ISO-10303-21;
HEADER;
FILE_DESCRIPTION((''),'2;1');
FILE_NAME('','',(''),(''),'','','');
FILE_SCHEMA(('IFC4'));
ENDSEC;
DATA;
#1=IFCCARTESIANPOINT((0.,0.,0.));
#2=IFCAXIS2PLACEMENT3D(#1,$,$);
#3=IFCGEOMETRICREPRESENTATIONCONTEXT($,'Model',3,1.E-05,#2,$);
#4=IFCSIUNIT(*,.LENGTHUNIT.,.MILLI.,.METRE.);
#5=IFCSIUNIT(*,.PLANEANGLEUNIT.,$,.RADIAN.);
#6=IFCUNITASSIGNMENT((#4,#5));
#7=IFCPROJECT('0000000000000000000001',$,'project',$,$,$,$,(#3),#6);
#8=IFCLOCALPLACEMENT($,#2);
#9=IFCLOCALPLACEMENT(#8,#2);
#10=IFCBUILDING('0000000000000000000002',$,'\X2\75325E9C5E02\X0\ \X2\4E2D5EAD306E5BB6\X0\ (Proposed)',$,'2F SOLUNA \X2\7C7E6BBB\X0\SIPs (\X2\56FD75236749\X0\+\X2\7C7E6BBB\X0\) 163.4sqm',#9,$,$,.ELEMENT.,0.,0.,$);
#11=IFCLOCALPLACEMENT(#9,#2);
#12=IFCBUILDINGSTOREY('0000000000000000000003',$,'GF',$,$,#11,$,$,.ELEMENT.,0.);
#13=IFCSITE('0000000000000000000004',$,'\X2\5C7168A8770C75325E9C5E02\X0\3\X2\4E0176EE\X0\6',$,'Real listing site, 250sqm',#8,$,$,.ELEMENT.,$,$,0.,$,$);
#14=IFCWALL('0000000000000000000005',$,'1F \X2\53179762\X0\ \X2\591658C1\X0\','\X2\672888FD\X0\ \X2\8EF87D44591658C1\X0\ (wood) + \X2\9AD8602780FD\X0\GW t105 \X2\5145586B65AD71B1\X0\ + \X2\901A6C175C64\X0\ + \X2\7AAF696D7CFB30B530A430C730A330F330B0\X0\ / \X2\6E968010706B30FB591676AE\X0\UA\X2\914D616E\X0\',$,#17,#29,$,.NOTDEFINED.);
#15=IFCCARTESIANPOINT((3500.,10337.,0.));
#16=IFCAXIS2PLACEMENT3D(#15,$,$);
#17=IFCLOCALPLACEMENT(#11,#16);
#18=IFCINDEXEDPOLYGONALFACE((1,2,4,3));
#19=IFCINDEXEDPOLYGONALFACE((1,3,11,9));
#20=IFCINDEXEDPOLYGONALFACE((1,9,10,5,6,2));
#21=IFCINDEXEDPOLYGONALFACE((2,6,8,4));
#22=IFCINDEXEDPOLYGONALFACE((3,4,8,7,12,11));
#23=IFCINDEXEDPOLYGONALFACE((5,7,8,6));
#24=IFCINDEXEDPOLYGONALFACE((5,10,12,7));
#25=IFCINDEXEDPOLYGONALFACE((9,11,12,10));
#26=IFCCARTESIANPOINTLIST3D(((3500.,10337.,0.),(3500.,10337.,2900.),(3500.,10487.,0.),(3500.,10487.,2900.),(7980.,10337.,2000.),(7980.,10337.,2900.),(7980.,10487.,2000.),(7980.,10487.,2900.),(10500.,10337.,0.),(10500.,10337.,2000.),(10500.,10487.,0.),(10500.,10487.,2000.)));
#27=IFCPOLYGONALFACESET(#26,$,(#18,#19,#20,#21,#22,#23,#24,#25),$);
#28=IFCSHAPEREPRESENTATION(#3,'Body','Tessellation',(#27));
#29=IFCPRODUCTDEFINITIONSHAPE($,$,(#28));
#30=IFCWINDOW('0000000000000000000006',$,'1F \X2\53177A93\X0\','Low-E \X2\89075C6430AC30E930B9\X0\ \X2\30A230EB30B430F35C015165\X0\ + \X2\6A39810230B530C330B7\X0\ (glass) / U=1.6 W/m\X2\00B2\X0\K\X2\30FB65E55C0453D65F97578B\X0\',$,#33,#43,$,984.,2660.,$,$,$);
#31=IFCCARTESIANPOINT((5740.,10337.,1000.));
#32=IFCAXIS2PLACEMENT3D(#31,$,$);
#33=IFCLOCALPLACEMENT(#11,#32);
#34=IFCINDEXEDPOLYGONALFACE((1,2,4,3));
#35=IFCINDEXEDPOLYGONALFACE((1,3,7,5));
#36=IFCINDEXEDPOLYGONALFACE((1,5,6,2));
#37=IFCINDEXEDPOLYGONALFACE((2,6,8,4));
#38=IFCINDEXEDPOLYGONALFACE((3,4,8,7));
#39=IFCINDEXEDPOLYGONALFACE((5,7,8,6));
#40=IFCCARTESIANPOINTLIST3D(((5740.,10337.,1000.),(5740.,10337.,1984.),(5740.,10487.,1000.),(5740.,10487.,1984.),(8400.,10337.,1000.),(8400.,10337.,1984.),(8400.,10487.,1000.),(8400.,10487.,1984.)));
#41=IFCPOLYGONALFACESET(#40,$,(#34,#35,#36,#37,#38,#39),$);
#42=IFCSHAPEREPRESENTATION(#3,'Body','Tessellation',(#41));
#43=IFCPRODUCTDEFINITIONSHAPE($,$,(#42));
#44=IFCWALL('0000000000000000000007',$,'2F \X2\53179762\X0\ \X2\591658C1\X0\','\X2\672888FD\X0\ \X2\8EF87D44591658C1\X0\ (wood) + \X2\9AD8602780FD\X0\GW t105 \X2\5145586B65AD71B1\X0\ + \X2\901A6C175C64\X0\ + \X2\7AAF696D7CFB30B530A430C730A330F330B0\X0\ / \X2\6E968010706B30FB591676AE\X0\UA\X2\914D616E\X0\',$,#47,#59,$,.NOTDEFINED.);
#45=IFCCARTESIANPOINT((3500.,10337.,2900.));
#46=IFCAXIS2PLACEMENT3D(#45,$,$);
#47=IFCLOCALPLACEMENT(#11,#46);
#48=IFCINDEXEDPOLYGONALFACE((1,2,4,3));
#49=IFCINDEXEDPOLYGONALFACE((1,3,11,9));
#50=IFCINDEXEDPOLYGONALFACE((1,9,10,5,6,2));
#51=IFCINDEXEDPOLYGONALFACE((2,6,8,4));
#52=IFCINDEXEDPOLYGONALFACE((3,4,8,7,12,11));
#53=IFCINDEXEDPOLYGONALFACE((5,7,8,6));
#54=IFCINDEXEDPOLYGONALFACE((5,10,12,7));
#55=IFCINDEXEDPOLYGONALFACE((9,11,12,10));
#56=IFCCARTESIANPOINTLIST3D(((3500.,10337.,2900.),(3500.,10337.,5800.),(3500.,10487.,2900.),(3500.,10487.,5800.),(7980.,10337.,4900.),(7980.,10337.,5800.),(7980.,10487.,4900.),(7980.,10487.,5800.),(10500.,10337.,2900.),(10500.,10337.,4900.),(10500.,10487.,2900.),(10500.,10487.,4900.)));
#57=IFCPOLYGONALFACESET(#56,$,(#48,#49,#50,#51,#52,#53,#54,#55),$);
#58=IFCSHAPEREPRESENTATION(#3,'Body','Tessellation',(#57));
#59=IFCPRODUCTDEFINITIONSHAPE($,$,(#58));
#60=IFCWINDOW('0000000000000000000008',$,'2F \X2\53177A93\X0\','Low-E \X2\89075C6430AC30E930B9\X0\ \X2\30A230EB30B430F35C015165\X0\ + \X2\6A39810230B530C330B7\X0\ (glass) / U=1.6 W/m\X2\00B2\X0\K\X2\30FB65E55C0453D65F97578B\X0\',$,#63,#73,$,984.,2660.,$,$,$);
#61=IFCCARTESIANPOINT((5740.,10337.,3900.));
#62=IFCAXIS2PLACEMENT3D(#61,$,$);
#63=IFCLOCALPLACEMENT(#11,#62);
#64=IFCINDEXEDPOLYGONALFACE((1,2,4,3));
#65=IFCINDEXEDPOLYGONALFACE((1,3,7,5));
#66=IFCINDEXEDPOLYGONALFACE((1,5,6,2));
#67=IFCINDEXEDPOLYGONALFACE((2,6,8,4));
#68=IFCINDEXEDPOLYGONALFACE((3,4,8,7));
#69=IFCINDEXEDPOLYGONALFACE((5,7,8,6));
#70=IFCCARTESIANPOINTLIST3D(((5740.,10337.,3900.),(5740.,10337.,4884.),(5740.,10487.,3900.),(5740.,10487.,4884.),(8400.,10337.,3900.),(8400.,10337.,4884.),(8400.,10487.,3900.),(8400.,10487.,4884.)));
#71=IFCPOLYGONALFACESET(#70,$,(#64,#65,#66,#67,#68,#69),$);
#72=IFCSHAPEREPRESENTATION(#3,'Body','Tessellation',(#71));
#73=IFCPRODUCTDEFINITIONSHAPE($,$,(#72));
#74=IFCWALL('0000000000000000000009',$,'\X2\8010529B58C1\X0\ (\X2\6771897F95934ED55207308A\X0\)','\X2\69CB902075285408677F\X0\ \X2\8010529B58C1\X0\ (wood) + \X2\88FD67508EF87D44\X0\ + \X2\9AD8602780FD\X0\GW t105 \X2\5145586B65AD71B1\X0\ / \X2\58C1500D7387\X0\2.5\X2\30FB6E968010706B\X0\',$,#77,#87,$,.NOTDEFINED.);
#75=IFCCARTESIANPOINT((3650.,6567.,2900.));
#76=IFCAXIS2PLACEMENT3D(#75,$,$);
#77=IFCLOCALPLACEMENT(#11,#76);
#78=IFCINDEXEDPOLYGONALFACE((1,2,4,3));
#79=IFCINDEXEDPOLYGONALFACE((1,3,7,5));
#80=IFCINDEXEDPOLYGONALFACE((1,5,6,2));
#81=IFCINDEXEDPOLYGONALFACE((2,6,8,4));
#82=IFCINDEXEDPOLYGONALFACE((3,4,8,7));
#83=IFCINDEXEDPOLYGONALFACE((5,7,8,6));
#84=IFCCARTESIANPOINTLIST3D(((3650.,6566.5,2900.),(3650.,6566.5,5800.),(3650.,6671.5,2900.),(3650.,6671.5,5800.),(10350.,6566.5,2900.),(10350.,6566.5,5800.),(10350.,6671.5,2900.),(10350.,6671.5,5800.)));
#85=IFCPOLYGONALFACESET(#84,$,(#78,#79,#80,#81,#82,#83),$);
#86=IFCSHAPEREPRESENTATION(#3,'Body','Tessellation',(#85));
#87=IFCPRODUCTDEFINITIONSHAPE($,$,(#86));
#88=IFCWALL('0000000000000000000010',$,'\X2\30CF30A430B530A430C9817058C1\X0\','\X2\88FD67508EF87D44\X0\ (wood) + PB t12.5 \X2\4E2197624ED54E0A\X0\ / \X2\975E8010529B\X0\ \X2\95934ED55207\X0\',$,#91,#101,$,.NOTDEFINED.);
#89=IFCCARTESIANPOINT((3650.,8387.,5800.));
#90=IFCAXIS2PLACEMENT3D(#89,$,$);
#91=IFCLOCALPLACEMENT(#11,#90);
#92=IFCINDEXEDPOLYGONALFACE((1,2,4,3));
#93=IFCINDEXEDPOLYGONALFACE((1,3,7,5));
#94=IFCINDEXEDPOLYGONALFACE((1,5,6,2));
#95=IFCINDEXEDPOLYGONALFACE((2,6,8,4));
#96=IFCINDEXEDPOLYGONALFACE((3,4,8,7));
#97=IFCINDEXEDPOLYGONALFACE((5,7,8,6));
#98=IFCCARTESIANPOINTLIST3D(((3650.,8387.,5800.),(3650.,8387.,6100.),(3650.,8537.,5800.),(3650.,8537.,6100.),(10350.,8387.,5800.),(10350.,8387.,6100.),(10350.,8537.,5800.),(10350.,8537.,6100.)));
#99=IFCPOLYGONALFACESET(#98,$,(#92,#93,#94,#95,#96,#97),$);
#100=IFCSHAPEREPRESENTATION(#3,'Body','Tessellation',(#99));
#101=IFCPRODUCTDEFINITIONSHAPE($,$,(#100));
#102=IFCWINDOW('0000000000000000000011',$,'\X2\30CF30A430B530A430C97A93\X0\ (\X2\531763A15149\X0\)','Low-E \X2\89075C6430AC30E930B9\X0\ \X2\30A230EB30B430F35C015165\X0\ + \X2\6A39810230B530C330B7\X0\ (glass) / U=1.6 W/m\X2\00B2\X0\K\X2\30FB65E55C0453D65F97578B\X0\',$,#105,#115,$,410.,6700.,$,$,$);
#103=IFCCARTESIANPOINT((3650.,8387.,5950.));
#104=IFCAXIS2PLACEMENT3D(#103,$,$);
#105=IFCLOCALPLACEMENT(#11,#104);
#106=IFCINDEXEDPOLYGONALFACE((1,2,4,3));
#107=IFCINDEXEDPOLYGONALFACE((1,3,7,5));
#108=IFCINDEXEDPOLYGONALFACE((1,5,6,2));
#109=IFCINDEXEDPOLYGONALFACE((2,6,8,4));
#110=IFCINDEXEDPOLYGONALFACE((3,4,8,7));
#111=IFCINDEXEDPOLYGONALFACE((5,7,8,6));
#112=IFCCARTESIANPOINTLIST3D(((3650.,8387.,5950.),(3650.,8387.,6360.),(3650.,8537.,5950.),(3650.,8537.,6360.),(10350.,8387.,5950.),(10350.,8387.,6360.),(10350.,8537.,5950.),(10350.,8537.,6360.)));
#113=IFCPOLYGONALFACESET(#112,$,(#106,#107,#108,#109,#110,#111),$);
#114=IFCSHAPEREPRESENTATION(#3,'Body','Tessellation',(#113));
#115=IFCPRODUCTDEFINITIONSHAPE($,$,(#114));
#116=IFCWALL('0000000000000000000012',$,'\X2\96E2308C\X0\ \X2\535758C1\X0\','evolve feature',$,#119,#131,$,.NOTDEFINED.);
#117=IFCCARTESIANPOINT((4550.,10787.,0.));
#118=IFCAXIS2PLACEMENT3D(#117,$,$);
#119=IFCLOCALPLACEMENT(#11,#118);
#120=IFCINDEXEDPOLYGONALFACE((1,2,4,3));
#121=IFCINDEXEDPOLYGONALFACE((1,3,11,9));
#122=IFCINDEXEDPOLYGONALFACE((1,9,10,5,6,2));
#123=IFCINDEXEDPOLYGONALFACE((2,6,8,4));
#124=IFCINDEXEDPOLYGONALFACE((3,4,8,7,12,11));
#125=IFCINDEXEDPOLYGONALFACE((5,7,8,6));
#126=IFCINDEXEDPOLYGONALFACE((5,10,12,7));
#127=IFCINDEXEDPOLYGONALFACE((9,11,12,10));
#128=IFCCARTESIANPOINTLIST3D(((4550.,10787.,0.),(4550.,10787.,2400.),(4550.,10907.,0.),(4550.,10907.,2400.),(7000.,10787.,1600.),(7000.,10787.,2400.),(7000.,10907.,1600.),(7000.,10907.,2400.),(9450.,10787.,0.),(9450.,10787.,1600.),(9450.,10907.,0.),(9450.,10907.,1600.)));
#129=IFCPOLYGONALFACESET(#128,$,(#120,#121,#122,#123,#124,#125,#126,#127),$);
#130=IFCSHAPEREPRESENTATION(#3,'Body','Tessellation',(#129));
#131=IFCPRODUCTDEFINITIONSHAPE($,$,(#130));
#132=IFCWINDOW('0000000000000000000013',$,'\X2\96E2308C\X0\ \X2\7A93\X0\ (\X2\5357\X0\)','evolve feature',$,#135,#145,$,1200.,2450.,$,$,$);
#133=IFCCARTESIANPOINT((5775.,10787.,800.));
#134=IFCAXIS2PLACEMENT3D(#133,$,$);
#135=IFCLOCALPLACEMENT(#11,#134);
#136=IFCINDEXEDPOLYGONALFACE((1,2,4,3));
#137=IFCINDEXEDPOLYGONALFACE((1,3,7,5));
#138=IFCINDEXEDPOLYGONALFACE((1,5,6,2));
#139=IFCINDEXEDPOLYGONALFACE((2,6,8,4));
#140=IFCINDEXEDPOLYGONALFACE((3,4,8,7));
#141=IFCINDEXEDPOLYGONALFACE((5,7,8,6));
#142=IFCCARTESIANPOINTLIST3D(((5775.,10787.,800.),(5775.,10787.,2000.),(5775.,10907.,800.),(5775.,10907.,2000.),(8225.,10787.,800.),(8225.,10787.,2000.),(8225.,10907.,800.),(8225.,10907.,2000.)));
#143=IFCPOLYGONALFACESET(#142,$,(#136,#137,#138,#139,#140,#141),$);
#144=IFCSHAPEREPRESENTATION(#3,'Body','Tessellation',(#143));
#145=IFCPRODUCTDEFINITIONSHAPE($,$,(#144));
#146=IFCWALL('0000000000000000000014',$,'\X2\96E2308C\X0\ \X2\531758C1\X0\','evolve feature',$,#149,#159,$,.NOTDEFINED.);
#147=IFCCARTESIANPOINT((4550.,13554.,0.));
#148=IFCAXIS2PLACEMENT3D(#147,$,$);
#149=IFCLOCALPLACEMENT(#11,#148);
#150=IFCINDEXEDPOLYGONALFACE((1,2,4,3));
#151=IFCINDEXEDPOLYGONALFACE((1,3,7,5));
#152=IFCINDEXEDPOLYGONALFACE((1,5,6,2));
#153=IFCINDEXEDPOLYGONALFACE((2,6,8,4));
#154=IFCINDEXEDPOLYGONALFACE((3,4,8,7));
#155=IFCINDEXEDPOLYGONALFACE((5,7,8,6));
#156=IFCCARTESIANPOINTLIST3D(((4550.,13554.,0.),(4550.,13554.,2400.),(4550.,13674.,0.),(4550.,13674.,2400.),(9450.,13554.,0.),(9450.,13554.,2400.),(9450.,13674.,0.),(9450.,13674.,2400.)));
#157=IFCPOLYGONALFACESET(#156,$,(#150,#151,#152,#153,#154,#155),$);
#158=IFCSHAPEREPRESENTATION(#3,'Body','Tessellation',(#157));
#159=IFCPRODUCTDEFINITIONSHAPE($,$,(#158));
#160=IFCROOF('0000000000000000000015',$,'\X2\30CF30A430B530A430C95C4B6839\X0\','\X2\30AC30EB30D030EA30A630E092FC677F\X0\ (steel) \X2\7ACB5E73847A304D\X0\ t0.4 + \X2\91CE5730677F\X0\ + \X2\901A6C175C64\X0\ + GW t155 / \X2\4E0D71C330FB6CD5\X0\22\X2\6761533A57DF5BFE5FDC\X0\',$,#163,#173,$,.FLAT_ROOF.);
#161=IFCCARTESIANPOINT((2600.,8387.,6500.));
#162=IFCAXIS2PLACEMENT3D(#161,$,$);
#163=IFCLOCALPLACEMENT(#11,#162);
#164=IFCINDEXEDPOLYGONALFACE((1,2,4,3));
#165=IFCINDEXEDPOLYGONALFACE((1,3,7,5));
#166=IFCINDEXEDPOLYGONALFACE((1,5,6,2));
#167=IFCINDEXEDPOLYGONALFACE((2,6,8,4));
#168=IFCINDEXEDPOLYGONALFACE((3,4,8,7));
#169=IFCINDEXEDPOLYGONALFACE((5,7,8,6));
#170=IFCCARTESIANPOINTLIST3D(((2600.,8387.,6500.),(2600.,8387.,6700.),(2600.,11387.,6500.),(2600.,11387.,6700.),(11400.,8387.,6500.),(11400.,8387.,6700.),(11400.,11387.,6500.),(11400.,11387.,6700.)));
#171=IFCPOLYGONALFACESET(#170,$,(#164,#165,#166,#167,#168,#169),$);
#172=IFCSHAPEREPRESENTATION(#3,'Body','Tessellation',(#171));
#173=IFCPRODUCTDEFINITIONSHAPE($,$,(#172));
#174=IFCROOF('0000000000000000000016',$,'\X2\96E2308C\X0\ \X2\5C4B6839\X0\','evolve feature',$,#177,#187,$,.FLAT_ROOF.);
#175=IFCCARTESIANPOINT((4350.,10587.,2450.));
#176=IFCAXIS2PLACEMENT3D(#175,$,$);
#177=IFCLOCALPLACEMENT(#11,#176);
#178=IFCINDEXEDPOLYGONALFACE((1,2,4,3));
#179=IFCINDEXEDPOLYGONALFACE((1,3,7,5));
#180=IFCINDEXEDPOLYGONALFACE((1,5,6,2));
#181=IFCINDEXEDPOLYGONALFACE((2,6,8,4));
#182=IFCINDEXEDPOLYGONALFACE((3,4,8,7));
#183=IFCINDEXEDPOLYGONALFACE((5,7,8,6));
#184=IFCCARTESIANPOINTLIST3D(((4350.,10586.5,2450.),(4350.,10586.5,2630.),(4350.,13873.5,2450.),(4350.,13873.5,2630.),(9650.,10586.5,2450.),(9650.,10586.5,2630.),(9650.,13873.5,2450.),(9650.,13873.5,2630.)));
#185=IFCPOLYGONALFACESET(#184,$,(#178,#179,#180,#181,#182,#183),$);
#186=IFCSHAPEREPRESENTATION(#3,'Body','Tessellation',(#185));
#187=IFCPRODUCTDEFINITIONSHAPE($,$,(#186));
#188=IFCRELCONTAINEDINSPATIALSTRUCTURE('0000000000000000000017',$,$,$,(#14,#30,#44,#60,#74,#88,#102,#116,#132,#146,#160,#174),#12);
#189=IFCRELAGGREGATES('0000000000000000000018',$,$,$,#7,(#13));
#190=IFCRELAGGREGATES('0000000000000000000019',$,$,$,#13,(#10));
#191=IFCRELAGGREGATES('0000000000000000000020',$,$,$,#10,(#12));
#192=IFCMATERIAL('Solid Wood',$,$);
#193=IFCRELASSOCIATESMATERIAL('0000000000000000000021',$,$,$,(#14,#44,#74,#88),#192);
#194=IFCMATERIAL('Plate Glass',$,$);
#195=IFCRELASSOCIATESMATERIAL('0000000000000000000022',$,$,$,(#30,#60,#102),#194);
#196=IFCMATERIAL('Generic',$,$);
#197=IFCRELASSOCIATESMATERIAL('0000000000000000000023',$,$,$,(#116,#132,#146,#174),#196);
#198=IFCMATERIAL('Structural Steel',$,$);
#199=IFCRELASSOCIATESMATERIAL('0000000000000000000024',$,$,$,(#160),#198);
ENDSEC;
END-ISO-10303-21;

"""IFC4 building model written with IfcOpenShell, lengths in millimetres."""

from ifc_helpers import new_model, si_unit, frame, frame_2d, origin, place, context, project, spatial, rectangle, extrude, material, element, fill, save


model = new_model("IFC4")

# Units and contexts
model_context = context("Model", 3, precision=1e-05, world=origin())
ifc_project = project(units=[si_unit("LENGTHUNIT", "METRE", prefix="MILLI"), si_unit("PLANEANGLEUNIT", "RADIAN")], contexts=[model_context])

# Site, building, storey
site_placement = place(None, origin())
site = spatial("IfcSite", under=ifc_project, at=site_placement, Name="山梨県甲府市3丁目6", ObjectType="Real listing site, 250sqm", CompositionType="ELEMENT", RefElevation=0.0)
building_placement = place(site_placement, origin())
building = spatial("IfcBuilding", under=site, at=building_placement, Name="甲府市 中庭の家 (Proposed)", ObjectType="2F SOLUNA 籾殻SIPs (国産杉+籾殻) 163.4sqm", CompositionType="ELEMENT", ElevationOfRefHeight=0.0, ElevationOfTerrain=0.0)
storey_placement = place(building_placement, origin())
storey = spatial("IfcBuildingStorey", under=building, at=storey_placement, Name="GF", CompositionType="ELEMENT", Elevation=0.0)

# Shared definitions
ifc_material_1 = material(Name="Generic")

# Wall, opening, window
ifc_material_2 = material(Name="Solid Wood")
wall_1_placement = place(storey_placement, frame((3500.0, 10337.0, 0.0)))
wall_1 = element("IfcWall", 1, at=wall_1_placement, inside=storey, material=ifc_material_2, Name="1F 北面 外壁", Description="木製 軸組外壁 (wood) + 高性能GW t105 充填断熱 + 通気層 + 窯業系サイディング / 準耐火・外皮UA配慮", PredefinedType="NOTDEFINED", context=model_context, shape_type="SweptSolid", body=[
    extrude(rectangle(XDim=7000.0, YDim=150.0, at=frame_2d((3500.0, 75.0))), frame((3500.0, 10337.0, 0.0)), (0.0, 0.0, 1.0), 2900.0),
])
opening_1_placement = place(storey_placement, frame((5740.0, 10337.0, 1000.0)))
opening_1 = element("IfcOpeningElement", 2, at=opening_1_placement, cuts=wall_1, PredefinedType="NOTDEFINED", context=model_context, shape_type="SweptSolid", body=[
    extrude(rectangle(XDim=2660.0, YDim=150.0, at=frame_2d((1330.0, 75.0))), frame((5740.0, 10337.0, 1000.0)), (0.0, 0.0, 1.0), 984.0),
])
ifc_material_3 = material(Name="Plate Glass")
window_1_placement = place(storey_placement, frame((5740.0, 10337.0, 1000.0)))
window_1 = element("IfcWindow", 3, at=window_1_placement, inside=storey, material=ifc_material_3, Name="1F 北窓", Description="Low-E 複層ガラス アルゴン封入 + 樹脂サッシ (glass) / U=1.6 W/m²K・日射取得型", OverallHeight=984.0, OverallWidth=2660.0, context=model_context, shape_type="SweptSolid", body=[
    extrude(rectangle(XDim=2660.0, YDim=150.0, at=frame_2d((1330.0, 75.0))), frame((5740.0, 10337.0, 1000.0)), (0.0, 0.0, 1.0), 984.0),
])
fill(opening_1, window_1)

# Wall, opening, window
wall_2_placement = place(storey_placement, frame((3500.0, 10337.0, 2900.0)))
wall_2 = element("IfcWall", 4, at=wall_2_placement, inside=storey, material=ifc_material_2, Name="2F 北面 外壁", Description="木製 軸組外壁 (wood) + 高性能GW t105 充填断熱 + 通気層 + 窯業系サイディング / 準耐火・外皮UA配慮", PredefinedType="NOTDEFINED", context=model_context, shape_type="SweptSolid", body=[
    extrude(rectangle(XDim=7000.0, YDim=150.0, at=frame_2d((3500.0, 75.0))), frame((3500.0, 10337.0, 2900.0)), (0.0, 0.0, 1.0), 2900.0),
])
opening_2_placement = place(storey_placement, frame((5740.0, 10337.0, 3900.0)))
opening_2 = element("IfcOpeningElement", 5, at=opening_2_placement, cuts=wall_2, PredefinedType="NOTDEFINED", context=model_context, shape_type="SweptSolid", body=[
    extrude(rectangle(XDim=2660.0, YDim=150.0, at=frame_2d((1330.0, 75.0))), frame((5740.0, 10337.0, 3900.0)), (0.0, 0.0, 1.0), 984.0),
])
window_2_placement = place(storey_placement, frame((5740.0, 10337.0, 3900.0)))
window_2 = element("IfcWindow", 6, at=window_2_placement, inside=storey, material=ifc_material_3, Name="2F 北窓", Description="Low-E 複層ガラス アルゴン封入 + 樹脂サッシ (glass) / U=1.6 W/m²K・日射取得型", OverallHeight=984.0, OverallWidth=2660.0, context=model_context, shape_type="SweptSolid", body=[
    extrude(rectangle(XDim=2660.0, YDim=150.0, at=frame_2d((1330.0, 75.0))), frame((5740.0, 10337.0, 3900.0)), (0.0, 0.0, 1.0), 984.0),
])
fill(opening_2, window_2)

# Wall
wall_3_placement = place(storey_placement, frame((3650.0, 6567.0, 2900.0)))
element("IfcWall", 7, at=wall_3_placement, inside=storey, material=ifc_material_2, Name="耐力壁 (東西間仕切り)", Description="構造用合板 耐力壁 (wood) + 製材軸組 + 高性能GW t105 充填断熱 / 壁倍率2.5・準耐火", PredefinedType="NOTDEFINED", context=model_context, shape_type="SweptSolid", body=[
    extrude(rectangle(XDim=6700.0, YDim=105.0, at=frame_2d((3350.0, 52.0))), frame((3650.0, 6567.0, 2900.0)), (0.0, 0.0, 1.0), 2900.0),
])

# Walls, openings, windows
wall_4_placement = place(storey_placement, frame((3650.0, 8387.0, 5800.0)))
wall_4 = element("IfcWall", 8, at=wall_4_placement, inside=storey, material=ifc_material_2, Name="ハイサイド腰壁", Description="製材軸組 (wood) + PB t12.5 両面仕上 / 非耐力 間仕切", PredefinedType="NOTDEFINED", context=model_context, shape_type="SweptSolid", body=[
    extrude(rectangle(XDim=6700.0, YDim=150.0, at=frame_2d((3350.0, 75.0))), frame((3650.0, 8387.0, 5800.0)), (0.0, 0.0, 1.0), 700.0),
])
opening_3_placement = place(storey_placement, frame((3650.0, 8387.0, 5950.0)))
opening_3 = element("IfcOpeningElement", 9, at=opening_3_placement, cuts=wall_4, PredefinedType="NOTDEFINED", context=model_context, shape_type="SweptSolid", body=[
    extrude(rectangle(XDim=6700.0, YDim=150.0, at=frame_2d((3350.0, 75.0))), frame((3650.0, 8387.0, 5950.0)), (0.0, 0.0, 1.0), 410.0),
])
window_3_placement = place(storey_placement, frame((3650.0, 8387.0, 5950.0)))
window_3 = element("IfcWindow", 10, at=window_3_placement, inside=storey, material=ifc_material_3, Name="ハイサイド窓 (北採光)", Description="Low-E 複層ガラス アルゴン封入 + 樹脂サッシ (glass) / U=1.6 W/m²K・日射取得型", OverallHeight=410.0, OverallWidth=6700.0, context=model_context, shape_type="SweptSolid", body=[
    extrude(rectangle(XDim=6700.0, YDim=150.0, at=frame_2d((3350.0, 75.0))), frame((3650.0, 8387.0, 5950.0)), (0.0, 0.0, 1.0), 410.0),
])
fill(opening_3, window_3)
wall_5_placement = place(storey_placement, frame((4550.0, 10787.0, 0.0)))
wall_5 = element("IfcWall", 11, at=wall_5_placement, inside=storey, material=ifc_material_1, Name="離れ 南壁", Description="evolve feature", PredefinedType="NOTDEFINED", context=model_context, shape_type="SweptSolid", body=[
    extrude(rectangle(XDim=4900.0, YDim=120.0, at=frame_2d((2450.0, 60.0))), frame((4550.0, 10787.0, 0.0)), (0.0, 0.0, 1.0), 2400.0),
])
opening_4_placement = place(storey_placement, frame((5775.0, 10787.0, 800.0)))
opening_4 = element("IfcOpeningElement", 12, at=opening_4_placement, cuts=wall_5, PredefinedType="NOTDEFINED", context=model_context, shape_type="SweptSolid", body=[
    extrude(rectangle(XDim=2450.0, YDim=120.0, at=frame_2d((1225.0, 60.0))), frame((5775.0, 10787.0, 800.0)), (0.0, 0.0, 1.0), 1200.0),
])
window_4_placement = place(storey_placement, frame((5775.0, 10787.0, 800.0)))
window_4 = element("IfcWindow", 13, at=window_4_placement, inside=storey, material=ifc_material_1, Name="離れ 窓 (南)", Description="evolve feature", OverallHeight=1200.0, OverallWidth=2450.0, context=model_context, shape_type="SweptSolid", body=[
    extrude(rectangle(XDim=2450.0, YDim=120.0, at=frame_2d((1225.0, 60.0))), frame((5775.0, 10787.0, 800.0)), (0.0, 0.0, 1.0), 1200.0),
])
fill(opening_4, window_4)

# Wall
wall_6_placement = place(storey_placement, frame((4550.0, 13554.0, 0.0)))
element("IfcWall", 14, at=wall_6_placement, inside=storey, material=ifc_material_1, Name="離れ 北壁", Description="evolve feature", PredefinedType="NOTDEFINED", context=model_context, shape_type="SweptSolid", body=[
    extrude(rectangle(XDim=4900.0, YDim=120.0, at=frame_2d((2450.0, 60.0))), frame((4550.0, 13554.0, 0.0)), (0.0, 0.0, 1.0), 2400.0),
])

# Roofs
ifc_material_4 = material(Name="Structural Steel")
roof_1_placement = place(storey_placement, frame((2600.0, 8387.0, 6500.0)))
element("IfcRoof", 15, at=roof_1_placement, inside=storey, material=ifc_material_4, Name="ハイサイド屋根", Description="ガルバリウム鋼板 (steel) 立平葺き t0.4 + 野地板 + 通気層 + GW t155 / 不燃・法22条区域対応", PredefinedType="FLAT_ROOF", context=model_context, shape_type="SweptSolid", body=[
    extrude(rectangle(XDim=8800.0, YDim=3000.0, at=frame_2d((4400.0, 1500.0))), frame((2600.0, 8387.0, 6500.0)), (0.0, 0.0, 1.0), 200.0),
])
roof_2_placement = place(storey_placement, frame((4350.0, 10587.0, 2450.0)))
element("IfcRoof", 16, at=roof_2_placement, inside=storey, material=ifc_material_1, Name="離れ 屋根", Description="evolve feature", PredefinedType="FLAT_ROOF", context=model_context, shape_type="SweptSolid", body=[
    extrude(rectangle(XDim=5300.0, YDim=3287.0, at=frame_2d((2650.0, 1643.0))), frame((4350.0, 10587.0, 2450.0)), (0.0, 0.0, 1.0), 180.0),
])

save(model, "model.ifc")
